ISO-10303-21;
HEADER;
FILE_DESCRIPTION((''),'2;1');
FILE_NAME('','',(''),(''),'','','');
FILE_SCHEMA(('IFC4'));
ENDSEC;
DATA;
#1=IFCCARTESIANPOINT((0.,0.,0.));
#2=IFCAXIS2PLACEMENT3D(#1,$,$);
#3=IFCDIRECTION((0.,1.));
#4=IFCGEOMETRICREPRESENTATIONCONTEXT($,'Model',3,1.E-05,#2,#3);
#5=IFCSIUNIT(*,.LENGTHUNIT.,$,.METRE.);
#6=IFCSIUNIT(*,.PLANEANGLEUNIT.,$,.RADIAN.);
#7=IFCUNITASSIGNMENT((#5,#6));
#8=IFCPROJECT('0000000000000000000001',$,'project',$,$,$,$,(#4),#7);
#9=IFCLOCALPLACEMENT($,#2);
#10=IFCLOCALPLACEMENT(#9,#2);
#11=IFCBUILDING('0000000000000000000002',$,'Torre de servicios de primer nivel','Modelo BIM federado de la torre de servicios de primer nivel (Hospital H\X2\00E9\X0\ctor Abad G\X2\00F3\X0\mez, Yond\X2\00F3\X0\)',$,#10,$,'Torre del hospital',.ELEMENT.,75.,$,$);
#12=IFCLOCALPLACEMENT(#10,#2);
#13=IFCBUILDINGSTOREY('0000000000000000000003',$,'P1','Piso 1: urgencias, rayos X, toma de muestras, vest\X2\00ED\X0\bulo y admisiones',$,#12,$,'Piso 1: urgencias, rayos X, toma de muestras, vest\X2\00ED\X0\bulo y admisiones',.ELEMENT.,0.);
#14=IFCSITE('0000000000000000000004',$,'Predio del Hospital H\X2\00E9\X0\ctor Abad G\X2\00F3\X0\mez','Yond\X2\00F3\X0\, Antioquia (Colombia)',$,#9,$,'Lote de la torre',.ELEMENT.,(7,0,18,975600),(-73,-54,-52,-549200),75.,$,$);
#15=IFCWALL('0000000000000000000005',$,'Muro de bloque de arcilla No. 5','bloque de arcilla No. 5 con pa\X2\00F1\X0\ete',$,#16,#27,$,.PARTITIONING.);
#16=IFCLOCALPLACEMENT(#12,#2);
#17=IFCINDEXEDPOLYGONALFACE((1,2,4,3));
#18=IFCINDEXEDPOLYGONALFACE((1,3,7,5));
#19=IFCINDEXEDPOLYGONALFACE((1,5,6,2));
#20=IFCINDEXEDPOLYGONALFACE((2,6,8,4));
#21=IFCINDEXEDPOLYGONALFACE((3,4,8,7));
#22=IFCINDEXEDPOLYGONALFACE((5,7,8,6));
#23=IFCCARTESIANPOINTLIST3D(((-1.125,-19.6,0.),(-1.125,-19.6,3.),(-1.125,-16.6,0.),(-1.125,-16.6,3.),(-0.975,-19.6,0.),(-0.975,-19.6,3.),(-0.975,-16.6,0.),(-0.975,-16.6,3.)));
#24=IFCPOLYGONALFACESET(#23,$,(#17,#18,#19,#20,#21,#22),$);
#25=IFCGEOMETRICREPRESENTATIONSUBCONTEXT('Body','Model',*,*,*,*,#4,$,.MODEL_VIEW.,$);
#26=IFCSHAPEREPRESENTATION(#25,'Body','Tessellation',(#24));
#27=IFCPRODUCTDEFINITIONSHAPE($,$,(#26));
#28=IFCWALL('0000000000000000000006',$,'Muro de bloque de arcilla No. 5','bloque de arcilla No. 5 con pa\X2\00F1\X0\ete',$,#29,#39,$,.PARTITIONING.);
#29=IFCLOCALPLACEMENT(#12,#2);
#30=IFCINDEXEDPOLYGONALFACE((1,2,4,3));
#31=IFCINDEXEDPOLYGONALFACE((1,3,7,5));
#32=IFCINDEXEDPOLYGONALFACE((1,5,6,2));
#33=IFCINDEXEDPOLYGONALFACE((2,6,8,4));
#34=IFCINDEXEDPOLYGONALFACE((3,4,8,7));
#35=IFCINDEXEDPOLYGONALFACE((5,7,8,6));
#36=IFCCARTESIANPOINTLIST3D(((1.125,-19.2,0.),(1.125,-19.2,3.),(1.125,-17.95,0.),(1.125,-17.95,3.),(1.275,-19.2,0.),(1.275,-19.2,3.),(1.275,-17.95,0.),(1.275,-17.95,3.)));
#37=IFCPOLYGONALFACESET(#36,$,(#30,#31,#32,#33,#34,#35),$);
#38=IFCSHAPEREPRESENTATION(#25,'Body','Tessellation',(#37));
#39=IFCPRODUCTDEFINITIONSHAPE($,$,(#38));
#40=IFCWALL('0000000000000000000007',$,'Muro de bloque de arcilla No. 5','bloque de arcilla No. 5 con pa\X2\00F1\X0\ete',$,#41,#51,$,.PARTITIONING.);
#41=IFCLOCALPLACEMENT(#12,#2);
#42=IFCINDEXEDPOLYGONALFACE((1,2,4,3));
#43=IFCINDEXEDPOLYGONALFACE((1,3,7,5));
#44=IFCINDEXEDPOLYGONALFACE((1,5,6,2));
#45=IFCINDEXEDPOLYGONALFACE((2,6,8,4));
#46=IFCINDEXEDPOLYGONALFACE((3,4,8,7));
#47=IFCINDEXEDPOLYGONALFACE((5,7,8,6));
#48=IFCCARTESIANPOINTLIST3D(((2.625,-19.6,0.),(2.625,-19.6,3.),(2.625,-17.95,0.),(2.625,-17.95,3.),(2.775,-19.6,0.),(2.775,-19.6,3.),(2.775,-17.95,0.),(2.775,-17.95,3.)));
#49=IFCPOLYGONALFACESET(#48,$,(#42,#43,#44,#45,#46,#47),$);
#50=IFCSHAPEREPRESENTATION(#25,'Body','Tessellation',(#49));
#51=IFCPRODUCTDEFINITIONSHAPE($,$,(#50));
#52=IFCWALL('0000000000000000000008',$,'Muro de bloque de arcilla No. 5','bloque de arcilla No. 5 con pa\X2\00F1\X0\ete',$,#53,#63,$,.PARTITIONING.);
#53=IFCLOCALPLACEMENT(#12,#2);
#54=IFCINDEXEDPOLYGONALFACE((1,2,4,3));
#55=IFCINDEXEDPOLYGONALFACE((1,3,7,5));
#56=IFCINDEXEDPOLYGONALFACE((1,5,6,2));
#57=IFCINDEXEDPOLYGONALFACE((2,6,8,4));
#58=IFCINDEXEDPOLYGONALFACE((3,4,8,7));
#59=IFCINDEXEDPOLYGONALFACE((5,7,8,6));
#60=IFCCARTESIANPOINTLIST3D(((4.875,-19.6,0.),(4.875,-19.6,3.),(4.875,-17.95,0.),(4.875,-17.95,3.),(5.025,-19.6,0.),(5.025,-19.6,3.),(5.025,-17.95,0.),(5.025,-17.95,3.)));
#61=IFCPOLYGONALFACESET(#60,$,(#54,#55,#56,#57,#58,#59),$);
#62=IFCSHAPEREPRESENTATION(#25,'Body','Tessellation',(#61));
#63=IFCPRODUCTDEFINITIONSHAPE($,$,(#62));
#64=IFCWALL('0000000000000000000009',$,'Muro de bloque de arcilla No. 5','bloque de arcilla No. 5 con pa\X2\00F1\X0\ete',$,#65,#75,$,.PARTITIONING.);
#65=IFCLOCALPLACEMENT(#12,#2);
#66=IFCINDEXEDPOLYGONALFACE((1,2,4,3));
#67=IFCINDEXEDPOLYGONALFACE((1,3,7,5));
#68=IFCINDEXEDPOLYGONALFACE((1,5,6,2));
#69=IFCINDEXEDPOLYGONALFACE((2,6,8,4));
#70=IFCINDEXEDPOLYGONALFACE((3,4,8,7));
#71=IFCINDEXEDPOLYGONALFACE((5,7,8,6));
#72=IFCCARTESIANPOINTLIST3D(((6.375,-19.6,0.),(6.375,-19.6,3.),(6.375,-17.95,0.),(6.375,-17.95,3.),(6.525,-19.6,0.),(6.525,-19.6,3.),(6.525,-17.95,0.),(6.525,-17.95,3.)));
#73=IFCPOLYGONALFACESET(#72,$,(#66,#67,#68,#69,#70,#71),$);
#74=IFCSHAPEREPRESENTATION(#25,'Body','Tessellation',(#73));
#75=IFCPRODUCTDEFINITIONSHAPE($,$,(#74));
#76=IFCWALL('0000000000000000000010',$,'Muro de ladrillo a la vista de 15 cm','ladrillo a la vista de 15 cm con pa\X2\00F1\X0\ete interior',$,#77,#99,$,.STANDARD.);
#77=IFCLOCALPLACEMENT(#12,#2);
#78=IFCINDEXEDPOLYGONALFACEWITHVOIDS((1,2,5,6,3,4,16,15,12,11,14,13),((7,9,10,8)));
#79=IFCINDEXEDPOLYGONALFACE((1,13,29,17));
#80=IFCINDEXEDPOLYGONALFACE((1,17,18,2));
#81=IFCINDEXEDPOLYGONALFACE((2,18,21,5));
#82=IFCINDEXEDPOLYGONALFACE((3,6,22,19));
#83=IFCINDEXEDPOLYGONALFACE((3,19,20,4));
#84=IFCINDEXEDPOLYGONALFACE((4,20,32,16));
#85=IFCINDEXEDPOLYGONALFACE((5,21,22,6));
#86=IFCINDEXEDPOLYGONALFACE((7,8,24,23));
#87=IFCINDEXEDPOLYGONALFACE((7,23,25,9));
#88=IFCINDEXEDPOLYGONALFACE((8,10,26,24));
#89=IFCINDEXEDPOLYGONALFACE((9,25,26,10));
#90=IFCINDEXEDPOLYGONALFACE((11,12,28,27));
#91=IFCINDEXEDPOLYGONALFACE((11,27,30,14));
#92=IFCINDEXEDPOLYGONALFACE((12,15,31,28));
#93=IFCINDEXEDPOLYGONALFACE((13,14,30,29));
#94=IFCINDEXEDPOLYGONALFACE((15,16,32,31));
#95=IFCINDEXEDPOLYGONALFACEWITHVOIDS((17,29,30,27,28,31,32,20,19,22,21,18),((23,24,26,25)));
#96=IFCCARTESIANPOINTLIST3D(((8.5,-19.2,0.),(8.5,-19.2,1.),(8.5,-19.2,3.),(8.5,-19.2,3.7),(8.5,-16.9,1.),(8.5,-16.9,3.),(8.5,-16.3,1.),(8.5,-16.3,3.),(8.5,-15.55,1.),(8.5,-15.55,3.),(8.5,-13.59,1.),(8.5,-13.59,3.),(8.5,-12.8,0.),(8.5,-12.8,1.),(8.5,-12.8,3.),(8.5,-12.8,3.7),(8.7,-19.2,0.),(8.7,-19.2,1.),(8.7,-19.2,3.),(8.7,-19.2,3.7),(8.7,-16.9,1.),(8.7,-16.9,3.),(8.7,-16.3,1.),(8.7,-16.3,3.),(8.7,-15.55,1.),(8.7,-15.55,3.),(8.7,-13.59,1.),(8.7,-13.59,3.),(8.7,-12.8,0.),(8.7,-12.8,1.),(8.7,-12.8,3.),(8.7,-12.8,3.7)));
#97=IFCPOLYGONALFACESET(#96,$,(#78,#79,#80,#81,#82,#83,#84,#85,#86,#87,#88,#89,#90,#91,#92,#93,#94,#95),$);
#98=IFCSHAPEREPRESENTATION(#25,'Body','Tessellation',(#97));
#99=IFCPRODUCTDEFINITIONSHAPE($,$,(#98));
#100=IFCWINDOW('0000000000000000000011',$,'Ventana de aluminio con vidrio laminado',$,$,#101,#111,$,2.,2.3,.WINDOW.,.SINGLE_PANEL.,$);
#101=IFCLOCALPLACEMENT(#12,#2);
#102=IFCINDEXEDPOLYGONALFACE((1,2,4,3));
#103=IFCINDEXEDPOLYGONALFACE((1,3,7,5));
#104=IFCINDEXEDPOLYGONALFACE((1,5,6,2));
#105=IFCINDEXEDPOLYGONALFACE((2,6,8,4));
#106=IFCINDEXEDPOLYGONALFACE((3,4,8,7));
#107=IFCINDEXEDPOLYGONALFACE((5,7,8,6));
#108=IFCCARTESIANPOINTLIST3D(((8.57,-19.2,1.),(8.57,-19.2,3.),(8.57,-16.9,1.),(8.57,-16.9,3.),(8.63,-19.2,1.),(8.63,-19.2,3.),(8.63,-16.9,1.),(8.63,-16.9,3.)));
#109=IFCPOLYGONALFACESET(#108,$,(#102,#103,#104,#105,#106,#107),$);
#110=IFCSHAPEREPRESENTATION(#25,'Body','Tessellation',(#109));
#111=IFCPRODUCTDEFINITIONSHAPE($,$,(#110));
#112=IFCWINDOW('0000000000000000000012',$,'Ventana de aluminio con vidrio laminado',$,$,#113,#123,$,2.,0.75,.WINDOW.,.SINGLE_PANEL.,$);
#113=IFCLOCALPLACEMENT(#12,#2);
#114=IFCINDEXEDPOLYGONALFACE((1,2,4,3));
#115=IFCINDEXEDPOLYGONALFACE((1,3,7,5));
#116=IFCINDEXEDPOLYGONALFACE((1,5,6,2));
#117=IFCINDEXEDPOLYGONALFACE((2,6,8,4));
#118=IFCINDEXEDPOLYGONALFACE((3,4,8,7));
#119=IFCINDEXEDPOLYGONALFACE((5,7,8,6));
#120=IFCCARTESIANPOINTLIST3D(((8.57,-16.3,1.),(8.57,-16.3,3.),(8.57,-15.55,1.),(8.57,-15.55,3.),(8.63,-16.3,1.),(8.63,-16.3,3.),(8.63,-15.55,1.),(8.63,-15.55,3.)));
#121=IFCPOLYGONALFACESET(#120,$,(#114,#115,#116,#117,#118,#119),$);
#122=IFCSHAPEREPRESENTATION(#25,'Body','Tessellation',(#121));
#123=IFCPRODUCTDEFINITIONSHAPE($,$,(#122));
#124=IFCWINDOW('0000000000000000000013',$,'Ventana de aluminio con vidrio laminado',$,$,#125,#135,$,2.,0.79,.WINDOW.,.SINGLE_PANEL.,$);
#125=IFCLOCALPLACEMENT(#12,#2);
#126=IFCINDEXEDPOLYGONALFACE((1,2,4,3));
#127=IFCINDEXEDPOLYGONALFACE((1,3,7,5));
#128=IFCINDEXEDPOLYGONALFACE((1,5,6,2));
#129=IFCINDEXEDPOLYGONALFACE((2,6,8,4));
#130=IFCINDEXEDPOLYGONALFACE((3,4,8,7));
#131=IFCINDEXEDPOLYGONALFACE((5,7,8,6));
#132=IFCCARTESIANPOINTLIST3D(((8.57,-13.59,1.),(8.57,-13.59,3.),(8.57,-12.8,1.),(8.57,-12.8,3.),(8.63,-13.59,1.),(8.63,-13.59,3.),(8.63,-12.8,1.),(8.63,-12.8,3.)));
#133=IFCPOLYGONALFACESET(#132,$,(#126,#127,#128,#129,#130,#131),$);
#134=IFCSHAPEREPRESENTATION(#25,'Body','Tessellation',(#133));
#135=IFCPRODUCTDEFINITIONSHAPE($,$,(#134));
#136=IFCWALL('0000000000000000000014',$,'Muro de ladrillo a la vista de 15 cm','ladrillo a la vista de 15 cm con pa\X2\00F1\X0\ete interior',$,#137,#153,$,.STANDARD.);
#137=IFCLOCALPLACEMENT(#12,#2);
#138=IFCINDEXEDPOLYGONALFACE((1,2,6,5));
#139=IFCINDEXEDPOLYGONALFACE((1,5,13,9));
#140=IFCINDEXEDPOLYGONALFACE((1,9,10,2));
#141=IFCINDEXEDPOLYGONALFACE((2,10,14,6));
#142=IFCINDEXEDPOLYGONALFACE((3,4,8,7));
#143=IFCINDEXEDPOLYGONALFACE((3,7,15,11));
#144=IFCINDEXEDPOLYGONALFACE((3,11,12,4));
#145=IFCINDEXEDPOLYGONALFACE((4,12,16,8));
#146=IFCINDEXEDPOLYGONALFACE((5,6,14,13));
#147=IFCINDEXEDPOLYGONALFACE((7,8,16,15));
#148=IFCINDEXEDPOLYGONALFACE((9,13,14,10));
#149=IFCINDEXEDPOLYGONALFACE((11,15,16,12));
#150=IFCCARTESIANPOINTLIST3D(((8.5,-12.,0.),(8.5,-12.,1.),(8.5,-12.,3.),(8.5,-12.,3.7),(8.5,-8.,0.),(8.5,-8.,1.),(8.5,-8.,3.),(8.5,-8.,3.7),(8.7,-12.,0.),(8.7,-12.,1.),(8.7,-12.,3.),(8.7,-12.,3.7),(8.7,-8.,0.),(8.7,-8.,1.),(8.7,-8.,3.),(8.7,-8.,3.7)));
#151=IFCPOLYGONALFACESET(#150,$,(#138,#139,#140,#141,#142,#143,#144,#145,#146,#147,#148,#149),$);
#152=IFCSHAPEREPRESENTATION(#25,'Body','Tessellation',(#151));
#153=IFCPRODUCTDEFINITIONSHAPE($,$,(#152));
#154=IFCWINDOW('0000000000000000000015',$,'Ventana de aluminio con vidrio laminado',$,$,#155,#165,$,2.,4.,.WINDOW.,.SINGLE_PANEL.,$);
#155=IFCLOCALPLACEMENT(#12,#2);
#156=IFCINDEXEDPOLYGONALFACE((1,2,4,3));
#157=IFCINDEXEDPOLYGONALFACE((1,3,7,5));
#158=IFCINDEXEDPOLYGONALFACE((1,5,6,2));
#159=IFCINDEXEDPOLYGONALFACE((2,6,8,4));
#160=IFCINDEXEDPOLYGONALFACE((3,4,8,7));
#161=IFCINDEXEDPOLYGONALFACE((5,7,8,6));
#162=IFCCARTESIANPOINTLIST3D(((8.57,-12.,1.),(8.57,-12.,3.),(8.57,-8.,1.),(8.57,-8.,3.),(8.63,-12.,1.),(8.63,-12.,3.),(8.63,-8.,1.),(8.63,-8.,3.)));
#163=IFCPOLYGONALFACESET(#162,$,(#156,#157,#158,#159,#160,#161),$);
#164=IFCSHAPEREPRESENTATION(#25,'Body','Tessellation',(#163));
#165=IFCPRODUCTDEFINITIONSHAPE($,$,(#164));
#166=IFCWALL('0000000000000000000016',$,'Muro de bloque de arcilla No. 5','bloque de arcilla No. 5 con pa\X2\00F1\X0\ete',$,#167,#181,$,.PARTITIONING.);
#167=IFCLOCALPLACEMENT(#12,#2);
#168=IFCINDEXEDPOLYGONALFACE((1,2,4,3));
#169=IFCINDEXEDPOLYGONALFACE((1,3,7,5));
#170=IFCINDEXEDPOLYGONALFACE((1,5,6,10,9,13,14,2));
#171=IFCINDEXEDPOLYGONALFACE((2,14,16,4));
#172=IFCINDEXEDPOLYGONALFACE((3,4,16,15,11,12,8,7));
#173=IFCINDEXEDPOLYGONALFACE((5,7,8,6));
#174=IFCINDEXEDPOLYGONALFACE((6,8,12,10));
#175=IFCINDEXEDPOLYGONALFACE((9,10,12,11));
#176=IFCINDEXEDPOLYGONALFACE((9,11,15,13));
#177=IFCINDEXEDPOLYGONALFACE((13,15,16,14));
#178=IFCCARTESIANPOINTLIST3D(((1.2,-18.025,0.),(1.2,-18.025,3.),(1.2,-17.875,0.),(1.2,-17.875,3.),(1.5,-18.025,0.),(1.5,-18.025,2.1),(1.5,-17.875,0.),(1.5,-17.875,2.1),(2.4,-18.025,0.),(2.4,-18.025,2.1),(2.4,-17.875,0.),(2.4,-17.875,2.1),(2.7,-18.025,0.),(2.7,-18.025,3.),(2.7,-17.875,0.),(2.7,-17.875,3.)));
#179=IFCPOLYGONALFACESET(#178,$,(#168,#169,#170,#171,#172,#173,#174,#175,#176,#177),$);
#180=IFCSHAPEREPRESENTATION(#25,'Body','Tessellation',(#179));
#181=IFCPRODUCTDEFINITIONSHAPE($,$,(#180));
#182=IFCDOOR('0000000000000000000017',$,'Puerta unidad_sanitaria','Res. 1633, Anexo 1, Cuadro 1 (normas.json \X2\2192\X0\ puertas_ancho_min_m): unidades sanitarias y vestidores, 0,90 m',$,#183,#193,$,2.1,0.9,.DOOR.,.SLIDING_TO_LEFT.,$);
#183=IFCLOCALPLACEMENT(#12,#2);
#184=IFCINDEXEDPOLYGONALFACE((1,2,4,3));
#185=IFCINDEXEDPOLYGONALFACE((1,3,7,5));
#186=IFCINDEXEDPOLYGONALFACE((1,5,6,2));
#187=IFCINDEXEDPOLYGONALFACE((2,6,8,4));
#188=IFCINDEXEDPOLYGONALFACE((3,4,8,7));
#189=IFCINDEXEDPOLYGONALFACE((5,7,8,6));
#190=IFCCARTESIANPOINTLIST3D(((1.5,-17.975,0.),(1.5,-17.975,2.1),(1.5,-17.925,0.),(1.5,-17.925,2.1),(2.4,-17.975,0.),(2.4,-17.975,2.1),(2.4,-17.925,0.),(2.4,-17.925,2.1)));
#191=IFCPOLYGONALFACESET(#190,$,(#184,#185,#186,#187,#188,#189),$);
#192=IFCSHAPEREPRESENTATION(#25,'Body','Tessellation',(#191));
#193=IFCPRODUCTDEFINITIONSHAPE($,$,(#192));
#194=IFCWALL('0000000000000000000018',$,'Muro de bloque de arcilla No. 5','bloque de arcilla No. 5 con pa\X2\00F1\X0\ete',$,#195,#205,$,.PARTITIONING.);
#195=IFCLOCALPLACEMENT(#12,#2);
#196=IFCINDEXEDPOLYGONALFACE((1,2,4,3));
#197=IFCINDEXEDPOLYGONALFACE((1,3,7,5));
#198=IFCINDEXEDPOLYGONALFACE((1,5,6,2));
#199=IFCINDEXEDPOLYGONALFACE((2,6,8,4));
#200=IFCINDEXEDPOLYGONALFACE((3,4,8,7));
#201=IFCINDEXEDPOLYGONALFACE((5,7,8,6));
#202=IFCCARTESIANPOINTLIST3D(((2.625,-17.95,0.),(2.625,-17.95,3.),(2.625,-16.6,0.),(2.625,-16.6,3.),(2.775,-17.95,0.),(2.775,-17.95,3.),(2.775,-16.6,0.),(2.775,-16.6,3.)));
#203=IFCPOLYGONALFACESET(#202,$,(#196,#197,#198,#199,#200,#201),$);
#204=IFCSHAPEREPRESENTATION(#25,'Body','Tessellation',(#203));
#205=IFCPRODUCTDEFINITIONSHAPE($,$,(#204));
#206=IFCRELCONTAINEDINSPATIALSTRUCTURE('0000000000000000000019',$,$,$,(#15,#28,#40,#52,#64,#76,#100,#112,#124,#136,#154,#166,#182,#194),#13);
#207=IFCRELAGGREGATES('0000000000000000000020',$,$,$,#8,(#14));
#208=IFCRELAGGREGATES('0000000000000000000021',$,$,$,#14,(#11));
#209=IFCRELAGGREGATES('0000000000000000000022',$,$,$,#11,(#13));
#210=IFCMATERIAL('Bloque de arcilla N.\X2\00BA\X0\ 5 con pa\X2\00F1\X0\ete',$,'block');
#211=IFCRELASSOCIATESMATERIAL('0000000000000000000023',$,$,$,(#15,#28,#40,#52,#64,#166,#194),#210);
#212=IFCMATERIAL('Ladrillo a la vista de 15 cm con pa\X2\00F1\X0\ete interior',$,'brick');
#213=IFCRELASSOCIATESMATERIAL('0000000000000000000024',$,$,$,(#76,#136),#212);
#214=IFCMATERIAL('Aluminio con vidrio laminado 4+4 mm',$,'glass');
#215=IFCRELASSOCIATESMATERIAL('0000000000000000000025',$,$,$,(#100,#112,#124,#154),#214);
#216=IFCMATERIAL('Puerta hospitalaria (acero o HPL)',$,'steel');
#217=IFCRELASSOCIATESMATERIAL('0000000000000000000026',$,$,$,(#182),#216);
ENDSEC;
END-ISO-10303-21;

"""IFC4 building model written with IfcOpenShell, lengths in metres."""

from ifc_helpers import new_model, si_unit, direction, frame, origin, place, context, subcontext, project, spatial, rectangle, extrude, material, element, fill, save


model = new_model("IFC4")

# Units and contexts
model_context = context("Model", 3, precision=1e-05, world=origin(), true_north=direction((0.0, 1.0)))
body_context = subcontext(model_context, "Body", "Model", "MODEL_VIEW")
ifc_project = project(units=[si_unit("LENGTHUNIT", "METRE"), si_unit("PLANEANGLEUNIT", "RADIAN")], contexts=[model_context])

# Site, building, storey
site_placement = place(None, origin())
site = spatial("IfcSite", under=ifc_project, at=site_placement, Name="Predio del Hospital Héctor Abad Gómez", Description="Yondó, Antioquia (Colombia)", LongName="Lote de la torre", CompositionType="ELEMENT", RefLatitude=(7, 0, 18, 975600), RefLongitude=(-73, -54, -52, -549200), RefElevation=75.0)
building_placement = place(site_placement, origin())
building = spatial("IfcBuilding", under=site, at=building_placement, Name="Torre de servicios de primer nivel", Description="Modelo BIM federado de la torre de servicios de primer nivel (Hospital Héctor Abad Gómez, Yondó)", LongName="Torre del hospital", CompositionType="ELEMENT", ElevationOfRefHeight=75.0)
placement = place(building_placement, origin())
storey = spatial("IfcBuildingStorey", under=building, at=placement, Name="P1", Description="Piso 1: urgencias, rayos X, toma de muestras, vestíbulo y admisiones", LongName="Piso 1: urgencias, rayos X, toma de muestras, vestíbulo y admisiones", CompositionType="ELEMENT", Elevation=0.0)

# Walls
ifc_material_1 = material(Name="Bloque de arcilla N.º 5 con pañete", Category="block")
element("IfcWall", 1, at=placement, inside=storey, material=ifc_material_1, Name="Muro de bloque de arcilla No. 5", Description="bloque de arcilla No. 5 con pañete", PredefinedType="PARTITIONING", context=body_context, shape_type="SweptSolid", body=[
    extrude(rectangle(XDim=0.15, YDim=3.0), frame((-1.05, -18.1, 0.0)), (0.0, 0.0, 1.0), 3.0),
])
element("IfcWall", 2, at=placement, inside=storey, material=ifc_material_1, Name="Muro de bloque de arcilla No. 5", Description="bloque de arcilla No. 5 con pañete", PredefinedType="PARTITIONING", context=body_context, shape_type="SweptSolid", body=[
    extrude(rectangle(XDim=0.15, YDim=1.25), frame((1.2, -18.575, 0.0)), (0.0, 0.0, 1.0), 3.0),
])
element("IfcWall", 3, at=placement, inside=storey, material=ifc_material_1, Name="Muro de bloque de arcilla No. 5", Description="bloque de arcilla No. 5 con pañete", PredefinedType="PARTITIONING", context=body_context, shape_type="SweptSolid", body=[
    extrude(rectangle(XDim=0.15, YDim=1.65), frame((2.7, -18.775, 0.0)), (0.0, 0.0, 1.0), 3.0),
])
element("IfcWall", 4, at=placement, inside=storey, material=ifc_material_1, Name="Muro de bloque de arcilla No. 5", Description="bloque de arcilla No. 5 con pañete", PredefinedType="PARTITIONING", context=body_context, shape_type="SweptSolid", body=[
    extrude(rectangle(XDim=0.15, YDim=1.65), frame((4.95, -18.775, 0.0)), (0.0, 0.0, 1.0), 3.0),
])
element("IfcWall", 5, at=placement, inside=storey, material=ifc_material_1, Name="Muro de bloque de arcilla No. 5", Description="bloque de arcilla No. 5 con pañete", PredefinedType="PARTITIONING", context=body_context, shape_type="SweptSolid", body=[
    extrude(rectangle(XDim=0.15, YDim=1.65), frame((6.45, -18.775, 0.0)), (0.0, 0.0, 1.0), 3.0),
])

# Wall, openings, windows
ifc_material_2 = material(Name="Ladrillo a la vista de 15 cm con pañete interior", Category="brick")
wall_1 = element("IfcWall", 6, at=placement, inside=storey, material=ifc_material_2, Name="Muro de ladrillo a la vista de 15 cm", Description="ladrillo a la vista de 15 cm con pañete interior", PredefinedType="STANDARD", context=body_context, shape_type="SweptSolid", body=[
    extrude(rectangle(XDim=0.2, YDim=6.4), frame((8.6, -16.0, 0.0)), (0.0, 0.0, 1.0), 3.7),
])
opening_1 = element("IfcOpeningElement", 7, at=placement, cuts=wall_1, PredefinedType="OPENING", context=body_context, shape_type="SweptSolid", body=[
    extrude(rectangle(XDim=0.3, YDim=2.3), frame((8.6, -18.05, 1.0)), (0.0, 0.0, 1.0), 2.0),
])
opening_2 = element("IfcOpeningElement", 8, at=placement, cuts=wall_1, PredefinedType="OPENING", context=body_context, shape_type="SweptSolid", body=[
    extrude(rectangle(XDim=0.3, YDim=0.75), frame((8.6, -15.925, 1.0)), (0.0, 0.0, 1.0), 2.0),
])
opening_3 = element("IfcOpeningElement", 9, at=placement, cuts=wall_1, PredefinedType="OPENING", context=body_context, shape_type="SweptSolid", body=[
    extrude(rectangle(XDim=0.3, YDim=0.79), frame((8.6, -13.195, 1.0)), (0.0, 0.0, 1.0), 2.0),
])
ifc_material_3 = material(Name="Aluminio con vidrio laminado 4+4 mm", Category="glass")
window_1 = element("IfcWindow", 10, at=placement, inside=storey, material=ifc_material_3, Name="Ventana de aluminio con vidrio laminado", OverallHeight=2.0, OverallWidth=2.3, PartitioningType="SINGLE_PANEL", PredefinedType="WINDOW", context=body_context, shape_type="SweptSolid", body=[
    extrude(rectangle(XDim=0.06, YDim=2.3), frame((8.6, -18.05, 1.0)), (0.0, 0.0, 1.0), 2.0),
])
fill(opening_1, window_1)
window_2 = element("IfcWindow", 11, at=placement, inside=storey, material=ifc_material_3, Name="Ventana de aluminio con vidrio laminado", OverallHeight=2.0, OverallWidth=0.75, PartitioningType="SINGLE_PANEL", PredefinedType="WINDOW", context=body_context, shape_type="SweptSolid", body=[
    extrude(rectangle(XDim=0.06, YDim=0.75), frame((8.6, -15.925, 1.0)), (0.0, 0.0, 1.0), 2.0),
])
fill(opening_2, window_2)
window_3 = element("IfcWindow", 12, at=placement, inside=storey, material=ifc_material_3, Name="Ventana de aluminio con vidrio laminado", OverallHeight=2.0, OverallWidth=0.79, PartitioningType="SINGLE_PANEL", PredefinedType="WINDOW", context=body_context, shape_type="SweptSolid", body=[
    extrude(rectangle(XDim=0.06, YDim=0.79), frame((8.6, -13.195, 1.0)), (0.0, 0.0, 1.0), 2.0),
])
fill(opening_3, window_3)

# Wall, opening, window
wall_2 = element("IfcWall", 13, at=placement, inside=storey, material=ifc_material_2, Name="Muro de ladrillo a la vista de 15 cm", Description="ladrillo a la vista de 15 cm con pañete interior", PredefinedType="STANDARD", context=body_context, shape_type="SweptSolid", body=[
    extrude(rectangle(XDim=0.2, YDim=4.0), frame((8.6, -10.0, 0.0)), (0.0, 0.0, 1.0), 3.7),
])
opening_4 = element("IfcOpeningElement", 14, at=placement, cuts=wall_2, PredefinedType="OPENING", context=body_context, shape_type="SweptSolid", body=[
    extrude(rectangle(XDim=0.3, YDim=4.0), frame((8.6, -10.0, 1.0)), (0.0, 0.0, 1.0), 2.0),
])
window_4 = element("IfcWindow", 15, at=placement, inside=storey, material=ifc_material_3, Name="Ventana de aluminio con vidrio laminado", OverallHeight=2.0, OverallWidth=4.0, PartitioningType="SINGLE_PANEL", PredefinedType="WINDOW", context=body_context, shape_type="SweptSolid", body=[
    extrude(rectangle(XDim=0.06, YDim=4.0), frame((8.6, -10.0, 1.0)), (0.0, 0.0, 1.0), 2.0),
])
fill(opening_4, window_4)

# Wall, opening, door
wall_3 = element("IfcWall", 16, at=placement, inside=storey, material=ifc_material_1, Name="Muro de bloque de arcilla No. 5", Description="bloque de arcilla No. 5 con pañete", PredefinedType="PARTITIONING", context=body_context, shape_type="SweptSolid", body=[
    extrude(rectangle(XDim=1.5, YDim=0.15), frame((1.95, -17.95, 0.0)), (0.0, 0.0, 1.0), 3.0),
])
opening_5 = element("IfcOpeningElement", 17, at=placement, cuts=wall_3, PredefinedType="OPENING", context=body_context, shape_type="SweptSolid", body=[
    extrude(rectangle(XDim=0.9, YDim=0.25), frame((1.95, -17.95, 0.0)), (0.0, 0.0, 1.0), 2.1),
])
ifc_material_4 = material(Name="Puerta hospitalaria (acero o HPL)", Category="steel")
door_1 = element("IfcDoor", 18, at=placement, inside=storey, material=ifc_material_4, Name="Puerta unidad_sanitaria", Description="Res. 1633, Anexo 1, Cuadro 1 (normas.json → puertas_ancho_min_m): unidades sanitarias y vestidores, 0,90 m", OperationType="SLIDING_TO_LEFT", OverallHeight=2.1, OverallWidth=0.9, PredefinedType="DOOR", context=body_context, shape_type="SweptSolid", body=[
    extrude(rectangle(XDim=0.9, YDim=0.05), frame((1.95, -17.95, 0.0)), (0.0, 0.0, 1.0), 2.1),
])
fill(opening_5, door_1)

# Wall
element("IfcWall", 19, at=placement, inside=storey, material=ifc_material_1, Name="Muro de bloque de arcilla No. 5", Description="bloque de arcilla No. 5 con pañete", PredefinedType="PARTITIONING", context=body_context, shape_type="SweptSolid", body=[
    extrude(rectangle(XDim=0.15, YDim=1.35), frame((2.7, -17.275, 0.0)), (0.0, 0.0, 1.0), 3.0),
])

save(model, "model.ifc")
